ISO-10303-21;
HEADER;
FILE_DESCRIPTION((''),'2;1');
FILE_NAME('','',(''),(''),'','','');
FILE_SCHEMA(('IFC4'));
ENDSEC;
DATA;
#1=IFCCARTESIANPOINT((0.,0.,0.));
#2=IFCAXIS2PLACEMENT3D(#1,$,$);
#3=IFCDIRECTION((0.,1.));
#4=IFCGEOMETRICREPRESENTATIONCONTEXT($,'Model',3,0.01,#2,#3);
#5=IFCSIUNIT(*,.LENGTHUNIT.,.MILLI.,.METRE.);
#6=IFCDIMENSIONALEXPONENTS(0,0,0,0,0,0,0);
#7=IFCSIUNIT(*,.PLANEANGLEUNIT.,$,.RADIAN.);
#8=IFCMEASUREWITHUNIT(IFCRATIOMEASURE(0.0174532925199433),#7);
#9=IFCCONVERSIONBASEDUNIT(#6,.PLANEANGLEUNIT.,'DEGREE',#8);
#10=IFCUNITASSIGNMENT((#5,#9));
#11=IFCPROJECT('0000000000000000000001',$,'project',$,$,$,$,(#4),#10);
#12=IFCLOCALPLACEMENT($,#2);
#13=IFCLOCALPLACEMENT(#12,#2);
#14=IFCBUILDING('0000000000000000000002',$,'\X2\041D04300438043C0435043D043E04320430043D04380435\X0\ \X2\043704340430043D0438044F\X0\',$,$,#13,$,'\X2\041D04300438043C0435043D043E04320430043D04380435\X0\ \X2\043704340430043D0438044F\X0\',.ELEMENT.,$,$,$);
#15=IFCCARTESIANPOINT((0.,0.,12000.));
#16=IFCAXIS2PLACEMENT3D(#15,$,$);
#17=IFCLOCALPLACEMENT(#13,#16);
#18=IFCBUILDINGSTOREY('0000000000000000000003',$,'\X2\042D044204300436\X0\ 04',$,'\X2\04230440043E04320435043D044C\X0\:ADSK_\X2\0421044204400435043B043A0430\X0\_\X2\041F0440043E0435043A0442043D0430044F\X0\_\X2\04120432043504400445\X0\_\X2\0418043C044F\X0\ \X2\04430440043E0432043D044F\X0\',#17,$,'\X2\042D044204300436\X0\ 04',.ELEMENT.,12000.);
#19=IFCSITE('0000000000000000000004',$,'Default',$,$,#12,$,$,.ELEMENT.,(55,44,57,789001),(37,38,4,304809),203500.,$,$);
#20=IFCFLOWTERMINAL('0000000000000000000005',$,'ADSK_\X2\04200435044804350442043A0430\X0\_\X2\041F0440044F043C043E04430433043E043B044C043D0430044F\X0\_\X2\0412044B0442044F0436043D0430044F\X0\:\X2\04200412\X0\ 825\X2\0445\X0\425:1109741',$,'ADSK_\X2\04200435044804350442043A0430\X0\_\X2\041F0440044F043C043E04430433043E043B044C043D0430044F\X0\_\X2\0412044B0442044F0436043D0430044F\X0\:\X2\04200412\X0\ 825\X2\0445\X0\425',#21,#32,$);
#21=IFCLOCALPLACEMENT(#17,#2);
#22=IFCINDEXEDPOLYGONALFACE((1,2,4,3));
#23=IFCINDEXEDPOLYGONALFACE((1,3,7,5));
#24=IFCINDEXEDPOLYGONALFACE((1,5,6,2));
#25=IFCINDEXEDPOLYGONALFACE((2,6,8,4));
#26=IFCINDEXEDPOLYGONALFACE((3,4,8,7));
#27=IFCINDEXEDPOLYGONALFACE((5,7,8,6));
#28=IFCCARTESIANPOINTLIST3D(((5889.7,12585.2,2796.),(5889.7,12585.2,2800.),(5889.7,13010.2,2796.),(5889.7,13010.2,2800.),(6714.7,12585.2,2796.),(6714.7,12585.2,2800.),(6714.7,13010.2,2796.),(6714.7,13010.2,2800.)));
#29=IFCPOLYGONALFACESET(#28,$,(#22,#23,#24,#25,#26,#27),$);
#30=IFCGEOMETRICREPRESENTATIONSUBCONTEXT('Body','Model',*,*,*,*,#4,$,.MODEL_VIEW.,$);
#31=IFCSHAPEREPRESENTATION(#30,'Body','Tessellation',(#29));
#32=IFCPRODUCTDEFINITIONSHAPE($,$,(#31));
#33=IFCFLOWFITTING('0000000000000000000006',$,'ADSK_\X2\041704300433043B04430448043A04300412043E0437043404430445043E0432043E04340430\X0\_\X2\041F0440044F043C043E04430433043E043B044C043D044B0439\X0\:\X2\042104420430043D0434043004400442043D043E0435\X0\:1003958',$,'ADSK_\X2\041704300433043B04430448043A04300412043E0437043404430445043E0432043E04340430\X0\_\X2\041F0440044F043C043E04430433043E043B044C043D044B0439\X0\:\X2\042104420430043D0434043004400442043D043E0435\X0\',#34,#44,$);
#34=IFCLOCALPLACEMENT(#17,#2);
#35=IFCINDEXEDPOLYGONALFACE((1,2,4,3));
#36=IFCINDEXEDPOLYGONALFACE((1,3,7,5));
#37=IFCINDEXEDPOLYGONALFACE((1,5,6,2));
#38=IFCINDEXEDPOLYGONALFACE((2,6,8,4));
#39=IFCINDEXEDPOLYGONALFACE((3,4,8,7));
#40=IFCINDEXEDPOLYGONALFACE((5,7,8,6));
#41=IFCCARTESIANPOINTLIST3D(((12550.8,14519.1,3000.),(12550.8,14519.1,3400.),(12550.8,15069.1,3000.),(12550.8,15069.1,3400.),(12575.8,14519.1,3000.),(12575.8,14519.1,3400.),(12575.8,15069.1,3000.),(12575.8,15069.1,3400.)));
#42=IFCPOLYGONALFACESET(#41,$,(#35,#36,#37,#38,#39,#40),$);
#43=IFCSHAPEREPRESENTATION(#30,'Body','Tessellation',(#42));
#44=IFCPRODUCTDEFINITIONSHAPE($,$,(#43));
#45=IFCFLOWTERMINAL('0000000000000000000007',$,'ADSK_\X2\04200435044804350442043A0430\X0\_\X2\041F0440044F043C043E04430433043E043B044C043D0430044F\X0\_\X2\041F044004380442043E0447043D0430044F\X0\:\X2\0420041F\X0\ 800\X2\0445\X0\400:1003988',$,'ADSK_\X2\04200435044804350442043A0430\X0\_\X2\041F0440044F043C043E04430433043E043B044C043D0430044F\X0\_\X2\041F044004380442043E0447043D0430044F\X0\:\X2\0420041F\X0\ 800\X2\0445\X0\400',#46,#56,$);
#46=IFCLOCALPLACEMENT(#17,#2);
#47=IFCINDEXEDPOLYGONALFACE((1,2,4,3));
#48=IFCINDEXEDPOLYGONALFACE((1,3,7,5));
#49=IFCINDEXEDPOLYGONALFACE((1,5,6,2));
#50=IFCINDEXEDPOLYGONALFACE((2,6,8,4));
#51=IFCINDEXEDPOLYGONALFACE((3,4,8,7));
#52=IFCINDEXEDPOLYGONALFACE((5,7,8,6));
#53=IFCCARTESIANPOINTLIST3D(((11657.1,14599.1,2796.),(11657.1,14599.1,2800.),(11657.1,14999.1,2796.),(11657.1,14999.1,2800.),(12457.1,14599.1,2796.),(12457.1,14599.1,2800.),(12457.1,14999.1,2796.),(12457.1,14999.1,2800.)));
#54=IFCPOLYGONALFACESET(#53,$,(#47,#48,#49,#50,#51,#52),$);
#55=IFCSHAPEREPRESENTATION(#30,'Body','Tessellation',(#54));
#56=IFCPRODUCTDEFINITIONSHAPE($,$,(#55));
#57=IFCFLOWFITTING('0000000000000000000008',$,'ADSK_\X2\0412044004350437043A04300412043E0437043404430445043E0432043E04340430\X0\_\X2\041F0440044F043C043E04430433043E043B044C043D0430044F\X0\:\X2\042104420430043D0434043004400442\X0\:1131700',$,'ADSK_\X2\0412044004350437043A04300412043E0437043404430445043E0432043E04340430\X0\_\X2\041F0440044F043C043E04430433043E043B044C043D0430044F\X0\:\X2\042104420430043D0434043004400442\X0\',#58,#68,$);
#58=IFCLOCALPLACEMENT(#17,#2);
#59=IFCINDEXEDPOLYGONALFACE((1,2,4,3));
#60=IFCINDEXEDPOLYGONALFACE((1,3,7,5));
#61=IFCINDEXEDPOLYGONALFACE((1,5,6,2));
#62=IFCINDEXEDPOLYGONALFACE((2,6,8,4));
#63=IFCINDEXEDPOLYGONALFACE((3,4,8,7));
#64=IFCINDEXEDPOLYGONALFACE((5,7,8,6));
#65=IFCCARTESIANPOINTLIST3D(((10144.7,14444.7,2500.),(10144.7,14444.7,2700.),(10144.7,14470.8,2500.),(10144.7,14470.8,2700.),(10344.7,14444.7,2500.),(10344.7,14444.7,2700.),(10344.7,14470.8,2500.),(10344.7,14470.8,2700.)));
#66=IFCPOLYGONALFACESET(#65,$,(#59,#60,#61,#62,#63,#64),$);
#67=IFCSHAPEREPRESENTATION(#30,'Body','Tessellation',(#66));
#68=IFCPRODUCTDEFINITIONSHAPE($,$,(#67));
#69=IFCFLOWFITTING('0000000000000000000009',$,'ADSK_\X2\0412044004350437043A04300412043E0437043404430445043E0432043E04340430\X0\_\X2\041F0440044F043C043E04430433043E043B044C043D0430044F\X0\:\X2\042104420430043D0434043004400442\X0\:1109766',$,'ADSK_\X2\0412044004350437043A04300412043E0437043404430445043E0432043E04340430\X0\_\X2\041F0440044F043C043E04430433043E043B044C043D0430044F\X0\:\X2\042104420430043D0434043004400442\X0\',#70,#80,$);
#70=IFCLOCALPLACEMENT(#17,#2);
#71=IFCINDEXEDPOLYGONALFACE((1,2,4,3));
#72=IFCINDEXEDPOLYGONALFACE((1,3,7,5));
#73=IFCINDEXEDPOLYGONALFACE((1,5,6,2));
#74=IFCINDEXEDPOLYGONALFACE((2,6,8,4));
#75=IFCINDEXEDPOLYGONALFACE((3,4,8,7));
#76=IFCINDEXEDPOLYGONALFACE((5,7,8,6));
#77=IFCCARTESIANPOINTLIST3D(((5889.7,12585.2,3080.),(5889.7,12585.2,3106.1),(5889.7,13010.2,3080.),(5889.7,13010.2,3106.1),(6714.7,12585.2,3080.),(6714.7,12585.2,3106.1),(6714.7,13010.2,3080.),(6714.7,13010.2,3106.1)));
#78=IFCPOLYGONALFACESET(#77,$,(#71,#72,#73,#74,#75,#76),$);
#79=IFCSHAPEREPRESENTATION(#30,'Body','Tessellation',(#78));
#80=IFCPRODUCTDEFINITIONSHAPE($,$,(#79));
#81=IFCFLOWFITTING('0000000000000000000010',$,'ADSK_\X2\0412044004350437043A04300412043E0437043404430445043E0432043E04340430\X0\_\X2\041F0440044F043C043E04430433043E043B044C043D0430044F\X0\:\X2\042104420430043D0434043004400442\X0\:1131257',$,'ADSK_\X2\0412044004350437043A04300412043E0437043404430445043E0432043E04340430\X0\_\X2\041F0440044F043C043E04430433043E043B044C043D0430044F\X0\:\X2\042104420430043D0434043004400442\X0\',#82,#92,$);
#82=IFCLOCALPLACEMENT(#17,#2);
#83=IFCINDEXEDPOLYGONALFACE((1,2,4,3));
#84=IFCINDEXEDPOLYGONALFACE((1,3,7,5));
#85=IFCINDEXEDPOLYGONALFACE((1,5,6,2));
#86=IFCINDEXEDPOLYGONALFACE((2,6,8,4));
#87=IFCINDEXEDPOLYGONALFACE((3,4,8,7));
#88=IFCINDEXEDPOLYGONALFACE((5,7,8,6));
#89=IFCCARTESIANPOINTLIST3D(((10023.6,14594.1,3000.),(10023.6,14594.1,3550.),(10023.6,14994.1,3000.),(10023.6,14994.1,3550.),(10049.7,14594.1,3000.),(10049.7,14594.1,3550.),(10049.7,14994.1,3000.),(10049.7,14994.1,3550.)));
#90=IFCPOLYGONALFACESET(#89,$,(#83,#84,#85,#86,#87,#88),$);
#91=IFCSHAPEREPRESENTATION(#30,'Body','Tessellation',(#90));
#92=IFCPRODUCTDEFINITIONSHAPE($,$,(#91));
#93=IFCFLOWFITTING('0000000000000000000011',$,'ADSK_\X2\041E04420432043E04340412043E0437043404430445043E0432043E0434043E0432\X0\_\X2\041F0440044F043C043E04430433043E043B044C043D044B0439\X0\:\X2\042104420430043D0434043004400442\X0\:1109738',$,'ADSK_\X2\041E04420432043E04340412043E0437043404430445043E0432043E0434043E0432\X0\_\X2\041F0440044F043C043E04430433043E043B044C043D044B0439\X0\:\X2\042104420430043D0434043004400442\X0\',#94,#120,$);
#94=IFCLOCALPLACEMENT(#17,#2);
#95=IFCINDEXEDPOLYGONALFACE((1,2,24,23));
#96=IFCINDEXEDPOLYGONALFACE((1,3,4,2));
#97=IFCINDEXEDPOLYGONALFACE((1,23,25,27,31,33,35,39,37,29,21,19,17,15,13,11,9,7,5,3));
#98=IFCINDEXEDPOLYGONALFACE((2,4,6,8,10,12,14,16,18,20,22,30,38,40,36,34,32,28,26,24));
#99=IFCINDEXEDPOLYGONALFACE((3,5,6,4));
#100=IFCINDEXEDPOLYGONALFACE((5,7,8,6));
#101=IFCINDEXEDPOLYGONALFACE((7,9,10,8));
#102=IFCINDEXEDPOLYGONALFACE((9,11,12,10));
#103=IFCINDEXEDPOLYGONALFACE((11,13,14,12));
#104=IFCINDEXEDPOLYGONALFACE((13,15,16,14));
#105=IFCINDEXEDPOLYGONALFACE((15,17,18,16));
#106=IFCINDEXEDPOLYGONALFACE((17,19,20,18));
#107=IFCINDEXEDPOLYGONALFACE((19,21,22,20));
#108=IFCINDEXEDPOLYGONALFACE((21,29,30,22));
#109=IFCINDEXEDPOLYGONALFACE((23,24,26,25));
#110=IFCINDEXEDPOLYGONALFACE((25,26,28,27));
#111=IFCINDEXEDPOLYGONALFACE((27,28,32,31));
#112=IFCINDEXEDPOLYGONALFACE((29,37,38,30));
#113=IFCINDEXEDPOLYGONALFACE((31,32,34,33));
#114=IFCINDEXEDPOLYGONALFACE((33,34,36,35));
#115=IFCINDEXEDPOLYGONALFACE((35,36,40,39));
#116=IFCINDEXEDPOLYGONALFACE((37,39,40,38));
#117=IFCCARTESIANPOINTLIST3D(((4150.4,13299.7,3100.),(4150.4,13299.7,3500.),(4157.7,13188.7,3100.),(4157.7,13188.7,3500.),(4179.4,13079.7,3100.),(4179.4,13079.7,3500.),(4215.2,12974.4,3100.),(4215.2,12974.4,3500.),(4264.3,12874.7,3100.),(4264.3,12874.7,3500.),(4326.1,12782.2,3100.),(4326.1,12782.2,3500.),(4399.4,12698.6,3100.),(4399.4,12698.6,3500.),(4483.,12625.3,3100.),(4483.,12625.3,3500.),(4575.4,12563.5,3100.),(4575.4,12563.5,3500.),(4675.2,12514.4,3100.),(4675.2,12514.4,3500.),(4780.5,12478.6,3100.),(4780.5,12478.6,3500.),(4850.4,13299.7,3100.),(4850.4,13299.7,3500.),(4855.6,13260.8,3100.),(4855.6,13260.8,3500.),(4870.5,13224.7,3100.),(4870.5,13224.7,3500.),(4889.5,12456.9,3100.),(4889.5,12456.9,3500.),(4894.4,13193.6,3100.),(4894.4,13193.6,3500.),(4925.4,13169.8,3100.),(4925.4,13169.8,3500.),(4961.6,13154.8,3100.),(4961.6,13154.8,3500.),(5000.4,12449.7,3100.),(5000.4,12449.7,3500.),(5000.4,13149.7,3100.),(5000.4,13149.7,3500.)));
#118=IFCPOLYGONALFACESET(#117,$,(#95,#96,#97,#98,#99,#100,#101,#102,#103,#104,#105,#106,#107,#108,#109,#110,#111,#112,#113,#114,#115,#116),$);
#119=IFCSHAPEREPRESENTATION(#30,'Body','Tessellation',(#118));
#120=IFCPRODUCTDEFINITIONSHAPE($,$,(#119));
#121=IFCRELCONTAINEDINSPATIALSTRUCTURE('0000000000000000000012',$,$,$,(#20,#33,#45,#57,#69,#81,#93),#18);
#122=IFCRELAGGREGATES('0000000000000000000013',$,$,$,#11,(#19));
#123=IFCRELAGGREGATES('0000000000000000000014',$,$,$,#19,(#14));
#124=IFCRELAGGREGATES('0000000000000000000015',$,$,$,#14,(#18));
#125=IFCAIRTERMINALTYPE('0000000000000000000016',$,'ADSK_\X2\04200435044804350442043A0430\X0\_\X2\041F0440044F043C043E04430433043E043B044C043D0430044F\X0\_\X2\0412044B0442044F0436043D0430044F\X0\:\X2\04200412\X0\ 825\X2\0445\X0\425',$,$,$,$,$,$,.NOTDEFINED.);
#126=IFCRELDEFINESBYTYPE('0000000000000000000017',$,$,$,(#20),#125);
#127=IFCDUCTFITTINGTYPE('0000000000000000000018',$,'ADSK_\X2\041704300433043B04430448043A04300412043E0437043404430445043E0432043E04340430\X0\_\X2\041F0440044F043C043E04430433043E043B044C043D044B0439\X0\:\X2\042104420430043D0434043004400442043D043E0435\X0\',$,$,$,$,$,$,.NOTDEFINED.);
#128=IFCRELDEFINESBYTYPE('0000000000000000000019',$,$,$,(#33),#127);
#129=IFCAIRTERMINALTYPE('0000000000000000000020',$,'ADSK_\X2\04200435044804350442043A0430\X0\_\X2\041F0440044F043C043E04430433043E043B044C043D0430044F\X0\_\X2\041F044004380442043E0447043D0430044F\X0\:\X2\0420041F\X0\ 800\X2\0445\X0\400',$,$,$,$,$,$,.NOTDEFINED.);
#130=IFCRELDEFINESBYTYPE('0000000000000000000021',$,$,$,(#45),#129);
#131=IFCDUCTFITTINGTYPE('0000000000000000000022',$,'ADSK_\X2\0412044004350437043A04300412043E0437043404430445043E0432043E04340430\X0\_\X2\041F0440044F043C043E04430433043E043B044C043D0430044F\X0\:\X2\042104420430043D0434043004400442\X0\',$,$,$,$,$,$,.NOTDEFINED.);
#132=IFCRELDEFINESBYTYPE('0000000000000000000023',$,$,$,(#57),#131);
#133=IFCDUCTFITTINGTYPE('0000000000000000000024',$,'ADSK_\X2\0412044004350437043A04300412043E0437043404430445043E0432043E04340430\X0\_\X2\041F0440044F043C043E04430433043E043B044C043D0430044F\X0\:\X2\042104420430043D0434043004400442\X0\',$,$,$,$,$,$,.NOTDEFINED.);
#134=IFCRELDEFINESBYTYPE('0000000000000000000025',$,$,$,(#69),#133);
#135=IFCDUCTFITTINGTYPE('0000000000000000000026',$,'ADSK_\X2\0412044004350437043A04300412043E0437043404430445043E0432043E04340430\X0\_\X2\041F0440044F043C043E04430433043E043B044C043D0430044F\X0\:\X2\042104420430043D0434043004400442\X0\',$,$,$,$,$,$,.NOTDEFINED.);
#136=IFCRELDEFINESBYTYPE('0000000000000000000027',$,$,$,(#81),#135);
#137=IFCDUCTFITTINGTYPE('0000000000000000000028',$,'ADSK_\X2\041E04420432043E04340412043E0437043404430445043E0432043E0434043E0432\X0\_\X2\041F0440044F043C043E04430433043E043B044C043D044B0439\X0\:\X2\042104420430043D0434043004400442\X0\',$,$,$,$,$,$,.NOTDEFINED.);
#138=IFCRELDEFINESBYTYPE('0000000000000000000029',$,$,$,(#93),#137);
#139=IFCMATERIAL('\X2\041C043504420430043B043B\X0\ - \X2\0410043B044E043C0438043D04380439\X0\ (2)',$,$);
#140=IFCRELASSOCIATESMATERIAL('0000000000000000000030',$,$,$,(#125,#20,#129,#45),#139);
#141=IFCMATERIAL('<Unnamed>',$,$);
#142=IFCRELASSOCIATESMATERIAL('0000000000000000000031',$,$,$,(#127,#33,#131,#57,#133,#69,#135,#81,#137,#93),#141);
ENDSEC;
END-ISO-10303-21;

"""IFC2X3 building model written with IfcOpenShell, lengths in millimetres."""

from ifc_helpers import new_model, entity, si_unit, converted_unit, direction, frame, frame_2d, origin, origin_2d_with_axis, place, context, subcontext, project, spatial, polyline, circle_curve, parameter, trimmed, segment, composite_curve, rectangle, outline, extrude, source, transform, mapped, material, type_object, type_shapes, element, save


model = new_model("IFC2X3")

# Units and contexts
model_context = context("Model", 3, precision=0.01, world=origin(), true_north=direction((0.0, 1.0)))
body_context = subcontext(model_context, "Body", "Model", "MODEL_VIEW")
ifc_project = project(units=[si_unit("LENGTHUNIT", "METRE", prefix="MILLI"), converted_unit("PLANEANGLEUNIT", "DEGREE", entity("IfcRatioMeasure", 0.0174532925199433), si_unit("PLANEANGLEUNIT", "RADIAN"), dimensions=[0, 0, 0, 0, 0, 0, 0])], contexts=[model_context])

# Site, building, storey
site_placement = place(None, origin())
site = spatial("IfcSite", under=ifc_project, at=site_placement, Name="Default", CompositionType="ELEMENT", RefLatitude=(55, 44, 57, 789001), RefLongitude=(37, 38, 4, 304809), RefElevation=203500.0)
building_placement = place(site_placement, origin())
building = spatial("IfcBuilding", under=site, at=building_placement, Name="Наименование здания", LongName="Наименование здания", CompositionType="ELEMENT")
storey_placement = place(building_placement, frame((0.0, 0.0, 12000.0)))
storey = spatial("IfcBuildingStorey", under=building, at=storey_placement, Name="Этаж 04", ObjectType="Уровень:ADSK_Стрелка_Проектная_Вверх_Имя уровня", LongName="Этаж 04", CompositionType="ELEMENT", Elevation=12000.0)

# Shared definitions
ifc_material_1 = material(Name="<Unnamed>")

# Flow terminal
ifc_material_2 = material(Name="Металл - Алюминий (2)")
air_terminal_type_1 = type_object("IfcAirTerminalType", Name="ADSK_Решетка_Прямоугольная_Вытяжная:РВ 825х425", PredefinedType="NOTDEFINED", material=ifc_material_2)
shared_shape_1 = source(origin(), body_context, "Body", "SweptSolid", [
    extrude(rectangle(XDim=4.0, YDim=825.0, at=origin_2d_with_axis()), frame((0.0, -2.0, -212.5), z_axis=(0.0, 0.0, 1.0), x_axis=(0.0, 1.0, 0.0)), (0.0, 0.0, 1.0), 425.0),
])
type_shapes(air_terminal_type_1, [shared_shape_1])
flow_terminal_1_placement = place(storey_placement, frame((6302.2, 12797.7, 2800.0), z_axis=(0.0, 1.0, 0.0), x_axis=(-1.0, 0.0, 0.0)))
element("IfcFlowTerminal", 1, at=flow_terminal_1_placement, inside=storey, type_object=air_terminal_type_1, material=ifc_material_2, Name="ADSK_Решетка_Прямоугольная_Вытяжная:РВ 825х425:1109741", ObjectType="ADSK_Решетка_Прямоугольная_Вытяжная:РВ 825х425", context=body_context, shape_type="MappedRepresentation", body=[
    mapped(shared_shape_1, transform((0.0, 0.0, 0.0), scale=1.0)),
])

# Flow fitting
duct_fitting_type_1 = type_object("IfcDuctFittingType", Name="ADSK_ЗаглушкаВоздуховода_Прямоугольный:Стандартное", PredefinedType="NOTDEFINED", material=ifc_material_1)
shared_shape_2 = source(origin(), body_context, "Body", "SweptSolid", [
    extrude(rectangle(XDim=25.0, YDim=550.0, at=origin_2d_with_axis()), frame((12.5, 0.0, -200.0)), (0.0, 0.0, 1.0), 400.0),
])
type_shapes(duct_fitting_type_1, [shared_shape_2])
flow_fitting_1_placement = place(storey_placement, frame((12550.8, 14794.1, 3200.0)))
element("IfcFlowFitting", 2, at=flow_fitting_1_placement, inside=storey, type_object=duct_fitting_type_1, material=ifc_material_1, Name="ADSK_ЗаглушкаВоздуховода_Прямоугольный:Стандартное:1003958", ObjectType="ADSK_ЗаглушкаВоздуховода_Прямоугольный:Стандартное", context=body_context, shape_type="MappedRepresentation", body=[
    mapped(shared_shape_2, transform((0.0, 0.0, 0.0), scale=1.0)),
])

# Flow terminal
air_terminal_type_2 = type_object("IfcAirTerminalType", Name="ADSK_Решетка_Прямоугольная_Приточная:РП 800х400", PredefinedType="NOTDEFINED", material=ifc_material_2)
shared_shape_3 = source(origin(), body_context, "Body", "SweptSolid", [
    extrude(rectangle(XDim=4.0, YDim=800.0, at=origin_2d_with_axis()), frame((0.0, -2.0, -200.0), z_axis=(0.0, 0.0, 1.0), x_axis=(0.0, 1.0, 0.0)), (0.0, 0.0, 1.0), 400.0),
])
type_shapes(air_terminal_type_2, [shared_shape_3])
flow_terminal_2_placement = place(storey_placement, frame((12057.1, 14799.1, 2800.0), z_axis=(0.0, 1.0, 0.0), x_axis=(-1.0, 0.0, 0.0)))
element("IfcFlowTerminal", 3, at=flow_terminal_2_placement, inside=storey, type_object=air_terminal_type_2, material=ifc_material_2, Name="ADSK_Решетка_Прямоугольная_Приточная:РП 800х400:1003988", ObjectType="ADSK_Решетка_Прямоугольная_Приточная:РП 800х400", context=body_context, shape_type="MappedRepresentation", body=[
    mapped(shared_shape_3, transform((0.0, 0.0, 0.0), scale=1.0)),
])

# Flow fittings
duct_fitting_type_2 = type_object("IfcDuctFittingType", Name="ADSK_ВрезкаВоздуховода_Прямоугольная:Стандарт", PredefinedType="NOTDEFINED", material=ifc_material_1)
shared_shape_4 = source(origin(), body_context, "Body", "SweptSolid", [
    extrude(rectangle(XDim=200.0, YDim=26.1, at=origin_2d_with_axis()), frame((7.0, 0.0, -100.0), z_axis=(0.0, 0.0, 1.0), x_axis=(0.0, -1.0, 0.0)), (0.0, 0.0, 1.0), 200.0),
])
type_shapes(duct_fitting_type_2, [shared_shape_4])
flow_fitting_2_placement = place(storey_placement, frame((10244.7, 14450.8, 2600.0), z_axis=(1.0, 0.0, 0.0), x_axis=(0.0, 1.0, 0.0)))
element("IfcFlowFitting", 4, at=flow_fitting_2_placement, inside=storey, type_object=duct_fitting_type_2, material=ifc_material_1, Name="ADSK_ВрезкаВоздуховода_Прямоугольная:Стандарт:1131700", ObjectType="ADSK_ВрезкаВоздуховода_Прямоугольная:Стандарт", context=body_context, shape_type="MappedRepresentation", body=[
    mapped(shared_shape_4, transform((0.0, 0.0, 0.0), scale=1.0)),
])
duct_fitting_type_3 = type_object("IfcDuctFittingType", Name="ADSK_ВрезкаВоздуховода_Прямоугольная:Стандарт", PredefinedType="NOTDEFINED", material=ifc_material_1)
shared_shape_5 = source(origin(), body_context, "Body", "SweptSolid", [
    extrude(rectangle(XDim=825.0, YDim=26.1, at=origin_2d_with_axis()), frame((7.0, 0.0, -212.5), z_axis=(0.0, 0.0, 1.0), x_axis=(0.0, -1.0, 0.0)), (0.0, 0.0, 1.0), 425.0),
])
type_shapes(duct_fitting_type_3, [shared_shape_5])
flow_fitting_3_placement = place(storey_placement, frame((6302.2, 12797.7, 3100.0), z_axis=(0.0, -1.0, 0.0), x_axis=(0.0, 0.0, -1.0)))
element("IfcFlowFitting", 5, at=flow_fitting_3_placement, inside=storey, type_object=duct_fitting_type_3, material=ifc_material_1, Name="ADSK_ВрезкаВоздуховода_Прямоугольная:Стандарт:1109766", ObjectType="ADSK_ВрезкаВоздуховода_Прямоугольная:Стандарт", context=body_context, shape_type="MappedRepresentation", body=[
    mapped(shared_shape_5, transform((0.0, 0.0, 0.0), scale=1.0)),
])
duct_fitting_type_4 = type_object("IfcDuctFittingType", Name="ADSK_ВрезкаВоздуховода_Прямоугольная:Стандарт", PredefinedType="NOTDEFINED", material=ifc_material_1)
shared_shape_6 = source(origin(), body_context, "Body", "SweptSolid", [
    extrude(rectangle(XDim=550.0, YDim=26.1, at=origin_2d_with_axis()), frame((7.0, 0.0, -200.0), z_axis=(0.0, 0.0, 1.0), x_axis=(0.0, -1.0, 0.0)), (0.0, 0.0, 1.0), 400.0),
])
type_shapes(duct_fitting_type_4, [shared_shape_6])
flow_fitting_4_placement = place(storey_placement, frame((10029.7, 14794.1, 3275.0), z_axis=(0.0, -1.0, 0.0), x_axis=(1.0, 0.0, 0.0)))
element("IfcFlowFitting", 6, at=flow_fitting_4_placement, inside=storey, type_object=duct_fitting_type_4, material=ifc_material_1, Name="ADSK_ВрезкаВоздуховода_Прямоугольная:Стандарт:1131257", ObjectType="ADSK_ВрезкаВоздуховода_Прямоугольная:Стандарт", context=body_context, shape_type="MappedRepresentation", body=[
    mapped(shared_shape_6, transform((0.0, 0.0, 0.0), scale=1.0)),
])
duct_fitting_type_5 = type_object("IfcDuctFittingType", Name="ADSK_ОтводВоздуховодов_Прямоугольный:Стандарт", PredefinedType="NOTDEFINED", material=ifc_material_1)
shared_shape_7 = source(origin(), body_context, "Body", "SweptSolid", [
    extrude(outline(composite_curve([segment(polyline([(-600.0, -250.0), (100.0, -250.0)]), True, "CONTINUOUS"), segment(trimmed(circle_curve(frame_2d((250.0, -250.0), x_axis=(0.0, 1.0)), 150.0), [parameter(0.0)], [parameter(90.0)], True, "PARAMETER"), False, "CONTINUOUS"), segment(polyline([(250.0, -100.0), (250.0, 600.0)]), True, "CONTINUOUS"), segment(trimmed(circle_curve(frame_2d((250.0, -250.0), x_axis=(0.0, 1.0)), 850.0), [parameter(0.0)], [parameter(90.0)], True, "PARAMETER"), True, "CONTINUOUS")], self_intersect=False)), frame((-250.0, 250.0, -200.0), z_axis=(0.0, 0.0, 1.0), x_axis=(-1.0, 0.0, 0.0)), (0.0, 0.0, 1.0), 400.0),
])
type_shapes(duct_fitting_type_5, [shared_shape_7])
flow_fitting_5_placement = place(storey_placement, frame((4500.4, 12799.7, 3300.0), z_axis=(0.0, 0.0, 1.0), x_axis=(0.0, -1.0, 0.0)))
element("IfcFlowFitting", 7, at=flow_fitting_5_placement, inside=storey, type_object=duct_fitting_type_5, material=ifc_material_1, Name="ADSK_ОтводВоздуховодов_Прямоугольный:Стандарт:1109738", ObjectType="ADSK_ОтводВоздуховодов_Прямоугольный:Стандарт", context=body_context, shape_type="MappedRepresentation", body=[
    mapped(shared_shape_7, transform((0.0, 0.0, 0.0), scale=1.0)),
])

save(model, "model.ifc")
